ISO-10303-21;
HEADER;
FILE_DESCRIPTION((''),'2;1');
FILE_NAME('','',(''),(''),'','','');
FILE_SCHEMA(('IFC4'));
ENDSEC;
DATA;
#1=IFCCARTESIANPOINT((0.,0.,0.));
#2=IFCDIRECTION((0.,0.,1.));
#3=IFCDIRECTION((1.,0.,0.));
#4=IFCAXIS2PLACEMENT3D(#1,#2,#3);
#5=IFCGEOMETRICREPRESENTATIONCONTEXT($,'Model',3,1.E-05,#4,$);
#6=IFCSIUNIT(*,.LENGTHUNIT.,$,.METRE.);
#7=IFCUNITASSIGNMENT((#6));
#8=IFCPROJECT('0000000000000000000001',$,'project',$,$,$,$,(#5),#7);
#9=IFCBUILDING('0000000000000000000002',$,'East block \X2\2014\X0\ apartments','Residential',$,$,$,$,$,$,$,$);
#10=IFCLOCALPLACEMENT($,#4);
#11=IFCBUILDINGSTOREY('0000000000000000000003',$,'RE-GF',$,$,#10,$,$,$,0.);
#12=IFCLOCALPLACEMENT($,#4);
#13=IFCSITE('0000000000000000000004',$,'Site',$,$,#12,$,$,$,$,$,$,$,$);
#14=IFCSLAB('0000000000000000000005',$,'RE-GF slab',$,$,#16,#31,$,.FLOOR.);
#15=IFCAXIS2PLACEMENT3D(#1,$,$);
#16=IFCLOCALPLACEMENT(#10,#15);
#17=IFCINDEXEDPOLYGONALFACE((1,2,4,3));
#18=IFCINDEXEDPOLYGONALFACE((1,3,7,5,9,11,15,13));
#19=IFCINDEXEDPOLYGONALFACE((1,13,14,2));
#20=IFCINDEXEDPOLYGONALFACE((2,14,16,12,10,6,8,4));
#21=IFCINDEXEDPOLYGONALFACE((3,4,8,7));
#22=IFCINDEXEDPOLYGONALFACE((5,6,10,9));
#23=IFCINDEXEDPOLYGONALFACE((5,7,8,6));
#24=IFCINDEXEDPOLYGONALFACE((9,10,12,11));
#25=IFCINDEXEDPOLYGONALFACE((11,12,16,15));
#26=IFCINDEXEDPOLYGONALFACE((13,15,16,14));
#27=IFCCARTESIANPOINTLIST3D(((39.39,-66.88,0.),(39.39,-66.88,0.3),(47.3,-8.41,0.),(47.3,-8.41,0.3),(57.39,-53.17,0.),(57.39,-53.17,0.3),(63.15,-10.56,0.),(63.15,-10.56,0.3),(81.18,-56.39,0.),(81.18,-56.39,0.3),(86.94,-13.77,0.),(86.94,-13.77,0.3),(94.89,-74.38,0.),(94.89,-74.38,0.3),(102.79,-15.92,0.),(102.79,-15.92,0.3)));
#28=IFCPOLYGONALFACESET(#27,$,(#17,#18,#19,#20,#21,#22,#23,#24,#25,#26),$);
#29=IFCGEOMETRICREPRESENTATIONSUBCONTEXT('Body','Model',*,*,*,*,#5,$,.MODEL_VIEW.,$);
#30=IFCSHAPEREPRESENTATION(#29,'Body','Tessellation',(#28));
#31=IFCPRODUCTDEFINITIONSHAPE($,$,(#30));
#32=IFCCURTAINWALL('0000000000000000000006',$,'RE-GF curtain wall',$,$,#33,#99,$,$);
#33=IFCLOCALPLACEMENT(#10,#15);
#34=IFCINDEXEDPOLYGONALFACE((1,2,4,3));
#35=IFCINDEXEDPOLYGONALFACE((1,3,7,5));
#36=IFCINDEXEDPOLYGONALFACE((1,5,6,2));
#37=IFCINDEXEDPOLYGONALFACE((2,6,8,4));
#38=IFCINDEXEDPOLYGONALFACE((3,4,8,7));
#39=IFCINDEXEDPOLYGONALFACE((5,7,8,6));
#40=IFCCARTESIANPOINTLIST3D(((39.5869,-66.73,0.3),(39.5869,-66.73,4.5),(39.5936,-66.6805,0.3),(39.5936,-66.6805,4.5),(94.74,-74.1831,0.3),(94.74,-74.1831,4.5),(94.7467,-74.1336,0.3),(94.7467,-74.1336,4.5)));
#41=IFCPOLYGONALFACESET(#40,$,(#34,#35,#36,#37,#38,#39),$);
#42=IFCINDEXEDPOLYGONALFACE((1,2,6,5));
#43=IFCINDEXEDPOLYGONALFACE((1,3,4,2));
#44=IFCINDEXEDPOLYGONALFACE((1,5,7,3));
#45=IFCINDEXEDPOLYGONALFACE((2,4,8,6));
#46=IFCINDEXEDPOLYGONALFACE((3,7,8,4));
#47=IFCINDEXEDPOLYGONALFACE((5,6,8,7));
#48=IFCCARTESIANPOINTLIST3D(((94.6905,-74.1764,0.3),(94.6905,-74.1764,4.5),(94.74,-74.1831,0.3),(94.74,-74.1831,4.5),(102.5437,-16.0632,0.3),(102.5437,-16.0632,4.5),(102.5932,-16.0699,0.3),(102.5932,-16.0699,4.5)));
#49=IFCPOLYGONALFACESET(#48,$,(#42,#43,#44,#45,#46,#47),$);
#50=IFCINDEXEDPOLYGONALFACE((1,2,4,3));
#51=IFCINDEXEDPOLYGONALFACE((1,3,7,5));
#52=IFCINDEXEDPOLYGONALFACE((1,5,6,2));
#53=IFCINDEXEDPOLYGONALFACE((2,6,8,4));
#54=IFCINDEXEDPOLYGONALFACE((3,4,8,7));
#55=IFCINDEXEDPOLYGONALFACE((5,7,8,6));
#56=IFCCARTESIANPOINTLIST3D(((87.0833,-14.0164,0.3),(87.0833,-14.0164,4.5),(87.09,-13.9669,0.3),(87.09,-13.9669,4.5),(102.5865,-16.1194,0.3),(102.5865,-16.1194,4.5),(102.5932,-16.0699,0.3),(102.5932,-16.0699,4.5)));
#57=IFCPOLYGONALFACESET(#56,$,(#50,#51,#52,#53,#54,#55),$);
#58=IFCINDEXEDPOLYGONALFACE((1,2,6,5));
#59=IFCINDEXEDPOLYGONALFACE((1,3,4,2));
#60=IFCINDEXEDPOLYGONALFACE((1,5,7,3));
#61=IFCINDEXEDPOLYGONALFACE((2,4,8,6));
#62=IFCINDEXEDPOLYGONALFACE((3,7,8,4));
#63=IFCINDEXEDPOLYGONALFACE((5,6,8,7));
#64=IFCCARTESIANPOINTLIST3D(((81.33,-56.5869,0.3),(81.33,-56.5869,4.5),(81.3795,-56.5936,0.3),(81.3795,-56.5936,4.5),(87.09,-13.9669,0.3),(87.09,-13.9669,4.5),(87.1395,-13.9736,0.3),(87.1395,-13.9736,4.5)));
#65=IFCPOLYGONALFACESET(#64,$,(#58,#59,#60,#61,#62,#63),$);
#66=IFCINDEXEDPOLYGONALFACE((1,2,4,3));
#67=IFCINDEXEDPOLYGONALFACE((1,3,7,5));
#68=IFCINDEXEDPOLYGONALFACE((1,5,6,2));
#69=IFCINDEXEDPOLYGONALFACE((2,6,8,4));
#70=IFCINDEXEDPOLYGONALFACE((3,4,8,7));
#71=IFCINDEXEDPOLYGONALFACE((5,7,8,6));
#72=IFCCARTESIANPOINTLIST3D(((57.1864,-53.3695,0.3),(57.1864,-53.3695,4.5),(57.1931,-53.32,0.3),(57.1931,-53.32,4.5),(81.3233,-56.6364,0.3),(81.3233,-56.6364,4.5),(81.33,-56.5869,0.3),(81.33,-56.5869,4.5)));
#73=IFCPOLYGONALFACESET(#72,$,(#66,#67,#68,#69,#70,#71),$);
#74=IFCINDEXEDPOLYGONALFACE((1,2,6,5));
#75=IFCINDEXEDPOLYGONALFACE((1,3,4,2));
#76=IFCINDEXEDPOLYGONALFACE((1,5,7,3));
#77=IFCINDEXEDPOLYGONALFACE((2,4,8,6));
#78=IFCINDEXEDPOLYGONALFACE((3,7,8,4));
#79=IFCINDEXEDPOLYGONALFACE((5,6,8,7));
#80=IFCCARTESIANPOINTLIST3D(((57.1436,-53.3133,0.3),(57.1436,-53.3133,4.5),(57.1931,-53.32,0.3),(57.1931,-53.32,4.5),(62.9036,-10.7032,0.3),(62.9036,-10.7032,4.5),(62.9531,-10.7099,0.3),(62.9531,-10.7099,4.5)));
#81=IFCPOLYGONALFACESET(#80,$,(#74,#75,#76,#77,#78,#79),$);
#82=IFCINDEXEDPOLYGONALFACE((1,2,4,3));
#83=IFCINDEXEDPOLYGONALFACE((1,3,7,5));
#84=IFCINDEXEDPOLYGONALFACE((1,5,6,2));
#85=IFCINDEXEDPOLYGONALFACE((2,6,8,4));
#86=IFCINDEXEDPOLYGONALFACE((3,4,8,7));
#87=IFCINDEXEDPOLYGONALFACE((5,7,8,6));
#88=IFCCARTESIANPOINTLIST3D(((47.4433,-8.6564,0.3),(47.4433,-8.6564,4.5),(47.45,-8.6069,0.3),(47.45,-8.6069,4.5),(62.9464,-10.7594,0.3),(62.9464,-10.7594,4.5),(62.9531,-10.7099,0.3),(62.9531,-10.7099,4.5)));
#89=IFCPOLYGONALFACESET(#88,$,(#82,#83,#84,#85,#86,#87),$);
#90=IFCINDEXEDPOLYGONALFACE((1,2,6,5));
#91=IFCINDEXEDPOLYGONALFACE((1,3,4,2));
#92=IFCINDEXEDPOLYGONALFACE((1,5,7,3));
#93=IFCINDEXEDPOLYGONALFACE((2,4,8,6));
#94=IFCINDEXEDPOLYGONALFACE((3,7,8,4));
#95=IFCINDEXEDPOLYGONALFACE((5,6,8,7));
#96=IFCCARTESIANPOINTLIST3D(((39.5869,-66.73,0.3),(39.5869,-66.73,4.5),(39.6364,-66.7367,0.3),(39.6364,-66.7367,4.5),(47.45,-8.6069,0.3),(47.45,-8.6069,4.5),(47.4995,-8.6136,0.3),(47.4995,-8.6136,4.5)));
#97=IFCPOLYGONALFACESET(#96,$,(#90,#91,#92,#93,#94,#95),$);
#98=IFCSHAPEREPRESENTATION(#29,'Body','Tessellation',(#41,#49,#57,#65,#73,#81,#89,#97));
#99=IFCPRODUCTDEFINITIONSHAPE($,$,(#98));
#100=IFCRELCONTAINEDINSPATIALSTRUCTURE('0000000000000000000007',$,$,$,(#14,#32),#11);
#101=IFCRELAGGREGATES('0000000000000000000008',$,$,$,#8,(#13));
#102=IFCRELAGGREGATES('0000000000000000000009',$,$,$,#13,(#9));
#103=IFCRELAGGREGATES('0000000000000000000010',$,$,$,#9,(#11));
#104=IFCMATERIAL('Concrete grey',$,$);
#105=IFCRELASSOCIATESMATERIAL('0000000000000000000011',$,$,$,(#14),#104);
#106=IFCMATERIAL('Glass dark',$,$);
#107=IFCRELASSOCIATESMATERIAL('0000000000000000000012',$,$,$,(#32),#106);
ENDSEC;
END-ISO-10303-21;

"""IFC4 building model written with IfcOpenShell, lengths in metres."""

from ifc_helpers import new_model, si_unit, frame, origin_with_axes, place, context, subcontext, project, spatial, polyline, outline, extrude, material, element, save


model = new_model("IFC4")

# Units and contexts
model_context = context("Model", 3, precision=1e-05, world=origin_with_axes())
body_context = subcontext(model_context, "Body", "Model", "MODEL_VIEW")
ifc_project = project(units=[si_unit("LENGTHUNIT", "METRE")], contexts=[model_context])

# Site, building, storey
site_placement = place(None, origin_with_axes())
site = spatial("IfcSite", under=ifc_project, at=site_placement, Name="Site")
building = spatial("IfcBuilding", under=site, Name="East block — apartments", Description="Residential")
storey_placement = place(None, origin_with_axes())
storey = spatial("IfcBuildingStorey", under=building, at=storey_placement, Name="RE-GF", Elevation=0.0)

# Slab
ifc_material_1 = material(Name="Concrete grey")
slab_placement = place(storey_placement, origin_with_axes())
element("IfcSlab", 1, at=slab_placement, inside=storey, material=ifc_material_1, Name="RE-GF slab", PredefinedType="FLOOR", context=body_context, shape_type="SweptSolid", body=[
    extrude(outline(polyline([(39.39, -66.88), (94.89, -74.38), (102.79, -15.92), (86.94, -13.77), (81.18, -56.39), (57.39, -53.17), (63.15, -10.56), (47.3, -8.41), (39.39, -66.88)])), origin_with_axes(), (0.0, 0.0, 1.0), 0.3),
])

# Curtain wall
ifc_material_2 = material(Name="Glass dark")
curtain_wall_placement = place(storey_placement, origin_with_axes())
element("IfcCurtainWall", 2, at=curtain_wall_placement, inside=storey, material=ifc_material_2, Name="RE-GF curtain wall", context=body_context, shape_type="SweptSolid", body=[
    extrude(outline(polyline([(39.5869, -66.73), (94.74, -74.1831), (94.7467, -74.1336), (39.5936, -66.6805), (39.5869, -66.73)])), frame((0.0, 0.0, 0.3), z_axis=(0.0, 0.0, 1.0), x_axis=(1.0, 0.0, 0.0)), (0.0, 0.0, 1.0), 4.2),
    extrude(outline(polyline([(94.74, -74.1831), (102.5932, -16.0699), (102.5437, -16.0632), (94.6905, -74.1764), (94.74, -74.1831)])), frame((0.0, 0.0, 0.3), z_axis=(0.0, 0.0, 1.0), x_axis=(1.0, 0.0, 0.0)), (0.0, 0.0, 1.0), 4.2),
    extrude(outline(polyline([(102.5932, -16.0699), (87.09, -13.9669), (87.0833, -14.0164), (102.5865, -16.1194), (102.5932, -16.0699)])), frame((0.0, 0.0, 0.3), z_axis=(0.0, 0.0, 1.0), x_axis=(1.0, 0.0, 0.0)), (0.0, 0.0, 1.0), 4.2),
    extrude(outline(polyline([(87.09, -13.9669), (81.33, -56.5869), (81.3795, -56.5936), (87.1395, -13.9736), (87.09, -13.9669)])), frame((0.0, 0.0, 0.3), z_axis=(0.0, 0.0, 1.0), x_axis=(1.0, 0.0, 0.0)), (0.0, 0.0, 1.0), 4.2),
    extrude(outline(polyline([(81.33, -56.5869), (57.1931, -53.32), (57.1864, -53.3695), (81.3233, -56.6364), (81.33, -56.5869)])), frame((0.0, 0.0, 0.3), z_axis=(0.0, 0.0, 1.0), x_axis=(1.0, 0.0, 0.0)), (0.0, 0.0, 1.0), 4.2),
    extrude(outline(polyline([(57.1931, -53.32), (62.9531, -10.7099), (62.9036, -10.7032), (57.1436, -53.3133), (57.1931, -53.32)])), frame((0.0, 0.0, 0.3), z_axis=(0.0, 0.0, 1.0), x_axis=(1.0, 0.0, 0.0)), (0.0, 0.0, 1.0), 4.2),
    extrude(outline(polyline([(62.9531, -10.7099), (47.45, -8.6069), (47.4433, -8.6564), (62.9464, -10.7594), (62.9531, -10.7099)])), frame((0.0, 0.0, 0.3), z_axis=(0.0, 0.0, 1.0), x_axis=(1.0, 0.0, 0.0)), (0.0, 0.0, 1.0), 4.2),
    extrude(outline(polyline([(47.45, -8.6069), (39.5869, -66.73), (39.6364, -66.7367), (47.4995, -8.6136), (47.45, -8.6069)])), frame((0.0, 0.0, 0.3), z_axis=(0.0, 0.0, 1.0), x_axis=(1.0, 0.0, 0.0)), (0.0, 0.0, 1.0), 4.2),
])

save(model, "model.ifc")
